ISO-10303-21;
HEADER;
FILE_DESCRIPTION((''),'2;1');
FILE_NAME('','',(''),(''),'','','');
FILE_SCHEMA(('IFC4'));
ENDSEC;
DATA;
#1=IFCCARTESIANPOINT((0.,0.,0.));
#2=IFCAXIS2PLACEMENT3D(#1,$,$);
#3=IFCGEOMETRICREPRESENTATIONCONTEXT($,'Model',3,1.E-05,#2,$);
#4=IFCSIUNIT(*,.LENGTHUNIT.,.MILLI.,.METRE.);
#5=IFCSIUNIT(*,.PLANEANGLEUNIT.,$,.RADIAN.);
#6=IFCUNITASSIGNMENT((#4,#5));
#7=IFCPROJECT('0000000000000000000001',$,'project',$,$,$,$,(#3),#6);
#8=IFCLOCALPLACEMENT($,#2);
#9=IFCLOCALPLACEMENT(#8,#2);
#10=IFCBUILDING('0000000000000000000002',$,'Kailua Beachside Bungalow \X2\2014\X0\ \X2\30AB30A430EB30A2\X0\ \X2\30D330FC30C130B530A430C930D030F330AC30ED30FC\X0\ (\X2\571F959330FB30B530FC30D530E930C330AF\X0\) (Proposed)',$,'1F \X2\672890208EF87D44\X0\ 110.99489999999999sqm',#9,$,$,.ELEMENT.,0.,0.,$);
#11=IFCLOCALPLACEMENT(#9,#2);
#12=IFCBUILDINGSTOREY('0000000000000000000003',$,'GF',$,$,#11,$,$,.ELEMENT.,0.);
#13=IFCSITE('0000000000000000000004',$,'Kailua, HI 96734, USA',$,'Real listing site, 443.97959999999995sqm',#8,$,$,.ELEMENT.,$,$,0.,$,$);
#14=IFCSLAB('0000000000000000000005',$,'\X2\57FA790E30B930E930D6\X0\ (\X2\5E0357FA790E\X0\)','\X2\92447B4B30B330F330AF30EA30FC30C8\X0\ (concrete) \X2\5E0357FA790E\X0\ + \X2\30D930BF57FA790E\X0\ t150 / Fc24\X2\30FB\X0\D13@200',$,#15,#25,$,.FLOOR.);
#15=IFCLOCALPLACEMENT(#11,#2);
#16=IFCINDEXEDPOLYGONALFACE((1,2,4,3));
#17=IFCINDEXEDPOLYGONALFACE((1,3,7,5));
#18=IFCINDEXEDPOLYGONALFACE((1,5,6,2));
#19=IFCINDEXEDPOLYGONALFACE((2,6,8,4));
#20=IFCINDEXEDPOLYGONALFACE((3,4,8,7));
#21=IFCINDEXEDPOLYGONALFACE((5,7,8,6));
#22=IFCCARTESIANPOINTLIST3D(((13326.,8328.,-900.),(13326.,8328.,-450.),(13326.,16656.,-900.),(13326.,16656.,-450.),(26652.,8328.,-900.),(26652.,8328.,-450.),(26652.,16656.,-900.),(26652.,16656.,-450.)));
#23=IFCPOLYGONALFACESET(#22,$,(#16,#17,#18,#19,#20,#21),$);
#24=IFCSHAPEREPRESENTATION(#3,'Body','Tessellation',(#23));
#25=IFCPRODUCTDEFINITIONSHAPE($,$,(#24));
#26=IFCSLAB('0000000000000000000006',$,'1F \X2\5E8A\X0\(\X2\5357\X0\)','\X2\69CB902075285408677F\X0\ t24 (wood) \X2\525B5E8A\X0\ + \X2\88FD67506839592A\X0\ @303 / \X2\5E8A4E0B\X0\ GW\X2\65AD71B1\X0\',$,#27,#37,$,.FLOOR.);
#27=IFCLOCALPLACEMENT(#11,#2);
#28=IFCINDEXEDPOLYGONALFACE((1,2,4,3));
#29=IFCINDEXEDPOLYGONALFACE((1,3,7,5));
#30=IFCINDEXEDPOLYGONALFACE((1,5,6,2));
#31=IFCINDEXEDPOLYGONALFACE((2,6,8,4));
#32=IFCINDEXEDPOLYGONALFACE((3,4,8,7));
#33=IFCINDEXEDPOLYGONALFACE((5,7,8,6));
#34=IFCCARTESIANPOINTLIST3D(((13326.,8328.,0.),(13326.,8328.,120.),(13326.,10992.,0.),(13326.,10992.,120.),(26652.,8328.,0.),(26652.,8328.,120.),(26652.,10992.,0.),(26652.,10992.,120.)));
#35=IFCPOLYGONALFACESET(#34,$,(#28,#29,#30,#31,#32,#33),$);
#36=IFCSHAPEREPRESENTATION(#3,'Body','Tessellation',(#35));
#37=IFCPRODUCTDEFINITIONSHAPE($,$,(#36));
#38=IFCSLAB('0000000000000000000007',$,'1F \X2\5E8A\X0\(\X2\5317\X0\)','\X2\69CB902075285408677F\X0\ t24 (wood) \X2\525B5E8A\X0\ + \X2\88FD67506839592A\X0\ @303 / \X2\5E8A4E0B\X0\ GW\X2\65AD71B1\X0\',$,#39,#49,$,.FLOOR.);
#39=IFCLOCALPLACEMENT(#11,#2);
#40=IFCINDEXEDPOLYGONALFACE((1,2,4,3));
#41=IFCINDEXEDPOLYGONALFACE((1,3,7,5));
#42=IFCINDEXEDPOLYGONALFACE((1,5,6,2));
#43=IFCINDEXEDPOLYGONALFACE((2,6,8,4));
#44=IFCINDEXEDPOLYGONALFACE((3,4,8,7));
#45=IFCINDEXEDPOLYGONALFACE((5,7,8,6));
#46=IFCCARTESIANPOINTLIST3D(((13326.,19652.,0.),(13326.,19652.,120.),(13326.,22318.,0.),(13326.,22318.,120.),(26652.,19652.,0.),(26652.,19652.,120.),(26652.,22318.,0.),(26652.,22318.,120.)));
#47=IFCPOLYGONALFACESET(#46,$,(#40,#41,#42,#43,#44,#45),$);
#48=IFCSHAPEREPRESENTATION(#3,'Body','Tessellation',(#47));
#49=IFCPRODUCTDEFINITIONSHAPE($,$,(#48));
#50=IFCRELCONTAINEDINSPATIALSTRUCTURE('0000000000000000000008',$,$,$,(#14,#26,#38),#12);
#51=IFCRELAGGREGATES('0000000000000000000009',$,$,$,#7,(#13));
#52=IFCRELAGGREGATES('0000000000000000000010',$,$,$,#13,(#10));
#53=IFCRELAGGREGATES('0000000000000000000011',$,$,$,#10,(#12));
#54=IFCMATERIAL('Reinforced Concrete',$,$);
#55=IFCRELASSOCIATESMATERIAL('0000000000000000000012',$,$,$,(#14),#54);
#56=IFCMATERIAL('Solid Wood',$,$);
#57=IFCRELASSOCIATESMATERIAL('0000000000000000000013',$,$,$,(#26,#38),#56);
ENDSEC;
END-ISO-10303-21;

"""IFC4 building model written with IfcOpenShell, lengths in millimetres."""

from ifc_helpers import new_model, si_unit, frame, frame_2d, origin, place, context, project, spatial, rectangle, extrude, material, element, save


model = new_model("IFC4")

# Units and contexts
model_context = context("Model", 3, precision=1e-05, world=origin())
ifc_project = project(units=[si_unit("LENGTHUNIT", "METRE", prefix="MILLI"), si_unit("PLANEANGLEUNIT", "RADIAN")], contexts=[model_context])

# Site, building, storey
site_placement = place(None, origin())
site = spatial("IfcSite", under=ifc_project, at=site_placement, Name="Kailua, HI 96734, USA", ObjectType="Real listing site, 443.97959999999995sqm", CompositionType="ELEMENT", RefElevation=0.0)
building_placement = place(site_placement, origin())
building = spatial("IfcBuilding", under=site, at=building_placement, Name="Kailua Beachside Bungalow — カイルア ビーチサイドバンガロー (土間・サーフラック) (Proposed)", ObjectType="1F 木造軸組 110.99489999999999sqm", CompositionType="ELEMENT", ElevationOfRefHeight=0.0, ElevationOfTerrain=0.0)
storey_placement = place(building_placement, origin())
storey = spatial("IfcBuildingStorey", under=building, at=storey_placement, Name="GF", CompositionType="ELEMENT", Elevation=0.0)

# Slabs
ifc_material_1 = material(Name="Reinforced Concrete")
slab_1_placement = place(storey_placement, frame((6663.0, 4164.0, -450.0)))
element("IfcSlab", 1, at=slab_1_placement, inside=storey, material=ifc_material_1, Name="基礎スラブ (布基礎)", Description="鉄筋コンクリート (concrete) 布基礎 + ベタ基礎 t150 / Fc24・D13@200", PredefinedType="FLOOR", context=model_context, shape_type="SweptSolid", body=[
    extrude(rectangle(XDim=13326.0, YDim=8328.0, at=frame_2d((6663.0, 4164.0))), frame((6663.0, 4164.0, -450.0)), (0.0, 0.0, 1.0), 450.0),
])
ifc_material_2 = material(Name="Solid Wood")
slab_2_placement = place(storey_placement, frame((6663.0, 4164.0, 0.0)))
element("IfcSlab", 2, at=slab_2_placement, inside=storey, material=ifc_material_2, Name="1F 床(南)", Description="構造用合板 t24 (wood) 剛床 + 製材根太 @303 / 床下 GW断熱", PredefinedType="FLOOR", context=model_context, shape_type="SweptSolid", body=[
    extrude(rectangle(XDim=13326.0, YDim=2664.0, at=frame_2d((6663.0, 1332.0))), frame((6663.0, 4164.0, 0.0)), (0.0, 0.0, 1.0), 120.0),
])
slab_3_placement = place(storey_placement, frame((6663.0, 9826.0, 0.0)))
element("IfcSlab", 3, at=slab_3_placement, inside=storey, material=ifc_material_2, Name="1F 床(北)", Description="構造用合板 t24 (wood) 剛床 + 製材根太 @303 / 床下 GW断熱", PredefinedType="FLOOR", context=model_context, shape_type="SweptSolid", body=[
    extrude(rectangle(XDim=13326.0, YDim=2666.0, at=frame_2d((6663.0, 1333.0))), frame((6663.0, 9826.0, 0.0)), (0.0, 0.0, 1.0), 120.0),
])

save(model, "model.ifc")
